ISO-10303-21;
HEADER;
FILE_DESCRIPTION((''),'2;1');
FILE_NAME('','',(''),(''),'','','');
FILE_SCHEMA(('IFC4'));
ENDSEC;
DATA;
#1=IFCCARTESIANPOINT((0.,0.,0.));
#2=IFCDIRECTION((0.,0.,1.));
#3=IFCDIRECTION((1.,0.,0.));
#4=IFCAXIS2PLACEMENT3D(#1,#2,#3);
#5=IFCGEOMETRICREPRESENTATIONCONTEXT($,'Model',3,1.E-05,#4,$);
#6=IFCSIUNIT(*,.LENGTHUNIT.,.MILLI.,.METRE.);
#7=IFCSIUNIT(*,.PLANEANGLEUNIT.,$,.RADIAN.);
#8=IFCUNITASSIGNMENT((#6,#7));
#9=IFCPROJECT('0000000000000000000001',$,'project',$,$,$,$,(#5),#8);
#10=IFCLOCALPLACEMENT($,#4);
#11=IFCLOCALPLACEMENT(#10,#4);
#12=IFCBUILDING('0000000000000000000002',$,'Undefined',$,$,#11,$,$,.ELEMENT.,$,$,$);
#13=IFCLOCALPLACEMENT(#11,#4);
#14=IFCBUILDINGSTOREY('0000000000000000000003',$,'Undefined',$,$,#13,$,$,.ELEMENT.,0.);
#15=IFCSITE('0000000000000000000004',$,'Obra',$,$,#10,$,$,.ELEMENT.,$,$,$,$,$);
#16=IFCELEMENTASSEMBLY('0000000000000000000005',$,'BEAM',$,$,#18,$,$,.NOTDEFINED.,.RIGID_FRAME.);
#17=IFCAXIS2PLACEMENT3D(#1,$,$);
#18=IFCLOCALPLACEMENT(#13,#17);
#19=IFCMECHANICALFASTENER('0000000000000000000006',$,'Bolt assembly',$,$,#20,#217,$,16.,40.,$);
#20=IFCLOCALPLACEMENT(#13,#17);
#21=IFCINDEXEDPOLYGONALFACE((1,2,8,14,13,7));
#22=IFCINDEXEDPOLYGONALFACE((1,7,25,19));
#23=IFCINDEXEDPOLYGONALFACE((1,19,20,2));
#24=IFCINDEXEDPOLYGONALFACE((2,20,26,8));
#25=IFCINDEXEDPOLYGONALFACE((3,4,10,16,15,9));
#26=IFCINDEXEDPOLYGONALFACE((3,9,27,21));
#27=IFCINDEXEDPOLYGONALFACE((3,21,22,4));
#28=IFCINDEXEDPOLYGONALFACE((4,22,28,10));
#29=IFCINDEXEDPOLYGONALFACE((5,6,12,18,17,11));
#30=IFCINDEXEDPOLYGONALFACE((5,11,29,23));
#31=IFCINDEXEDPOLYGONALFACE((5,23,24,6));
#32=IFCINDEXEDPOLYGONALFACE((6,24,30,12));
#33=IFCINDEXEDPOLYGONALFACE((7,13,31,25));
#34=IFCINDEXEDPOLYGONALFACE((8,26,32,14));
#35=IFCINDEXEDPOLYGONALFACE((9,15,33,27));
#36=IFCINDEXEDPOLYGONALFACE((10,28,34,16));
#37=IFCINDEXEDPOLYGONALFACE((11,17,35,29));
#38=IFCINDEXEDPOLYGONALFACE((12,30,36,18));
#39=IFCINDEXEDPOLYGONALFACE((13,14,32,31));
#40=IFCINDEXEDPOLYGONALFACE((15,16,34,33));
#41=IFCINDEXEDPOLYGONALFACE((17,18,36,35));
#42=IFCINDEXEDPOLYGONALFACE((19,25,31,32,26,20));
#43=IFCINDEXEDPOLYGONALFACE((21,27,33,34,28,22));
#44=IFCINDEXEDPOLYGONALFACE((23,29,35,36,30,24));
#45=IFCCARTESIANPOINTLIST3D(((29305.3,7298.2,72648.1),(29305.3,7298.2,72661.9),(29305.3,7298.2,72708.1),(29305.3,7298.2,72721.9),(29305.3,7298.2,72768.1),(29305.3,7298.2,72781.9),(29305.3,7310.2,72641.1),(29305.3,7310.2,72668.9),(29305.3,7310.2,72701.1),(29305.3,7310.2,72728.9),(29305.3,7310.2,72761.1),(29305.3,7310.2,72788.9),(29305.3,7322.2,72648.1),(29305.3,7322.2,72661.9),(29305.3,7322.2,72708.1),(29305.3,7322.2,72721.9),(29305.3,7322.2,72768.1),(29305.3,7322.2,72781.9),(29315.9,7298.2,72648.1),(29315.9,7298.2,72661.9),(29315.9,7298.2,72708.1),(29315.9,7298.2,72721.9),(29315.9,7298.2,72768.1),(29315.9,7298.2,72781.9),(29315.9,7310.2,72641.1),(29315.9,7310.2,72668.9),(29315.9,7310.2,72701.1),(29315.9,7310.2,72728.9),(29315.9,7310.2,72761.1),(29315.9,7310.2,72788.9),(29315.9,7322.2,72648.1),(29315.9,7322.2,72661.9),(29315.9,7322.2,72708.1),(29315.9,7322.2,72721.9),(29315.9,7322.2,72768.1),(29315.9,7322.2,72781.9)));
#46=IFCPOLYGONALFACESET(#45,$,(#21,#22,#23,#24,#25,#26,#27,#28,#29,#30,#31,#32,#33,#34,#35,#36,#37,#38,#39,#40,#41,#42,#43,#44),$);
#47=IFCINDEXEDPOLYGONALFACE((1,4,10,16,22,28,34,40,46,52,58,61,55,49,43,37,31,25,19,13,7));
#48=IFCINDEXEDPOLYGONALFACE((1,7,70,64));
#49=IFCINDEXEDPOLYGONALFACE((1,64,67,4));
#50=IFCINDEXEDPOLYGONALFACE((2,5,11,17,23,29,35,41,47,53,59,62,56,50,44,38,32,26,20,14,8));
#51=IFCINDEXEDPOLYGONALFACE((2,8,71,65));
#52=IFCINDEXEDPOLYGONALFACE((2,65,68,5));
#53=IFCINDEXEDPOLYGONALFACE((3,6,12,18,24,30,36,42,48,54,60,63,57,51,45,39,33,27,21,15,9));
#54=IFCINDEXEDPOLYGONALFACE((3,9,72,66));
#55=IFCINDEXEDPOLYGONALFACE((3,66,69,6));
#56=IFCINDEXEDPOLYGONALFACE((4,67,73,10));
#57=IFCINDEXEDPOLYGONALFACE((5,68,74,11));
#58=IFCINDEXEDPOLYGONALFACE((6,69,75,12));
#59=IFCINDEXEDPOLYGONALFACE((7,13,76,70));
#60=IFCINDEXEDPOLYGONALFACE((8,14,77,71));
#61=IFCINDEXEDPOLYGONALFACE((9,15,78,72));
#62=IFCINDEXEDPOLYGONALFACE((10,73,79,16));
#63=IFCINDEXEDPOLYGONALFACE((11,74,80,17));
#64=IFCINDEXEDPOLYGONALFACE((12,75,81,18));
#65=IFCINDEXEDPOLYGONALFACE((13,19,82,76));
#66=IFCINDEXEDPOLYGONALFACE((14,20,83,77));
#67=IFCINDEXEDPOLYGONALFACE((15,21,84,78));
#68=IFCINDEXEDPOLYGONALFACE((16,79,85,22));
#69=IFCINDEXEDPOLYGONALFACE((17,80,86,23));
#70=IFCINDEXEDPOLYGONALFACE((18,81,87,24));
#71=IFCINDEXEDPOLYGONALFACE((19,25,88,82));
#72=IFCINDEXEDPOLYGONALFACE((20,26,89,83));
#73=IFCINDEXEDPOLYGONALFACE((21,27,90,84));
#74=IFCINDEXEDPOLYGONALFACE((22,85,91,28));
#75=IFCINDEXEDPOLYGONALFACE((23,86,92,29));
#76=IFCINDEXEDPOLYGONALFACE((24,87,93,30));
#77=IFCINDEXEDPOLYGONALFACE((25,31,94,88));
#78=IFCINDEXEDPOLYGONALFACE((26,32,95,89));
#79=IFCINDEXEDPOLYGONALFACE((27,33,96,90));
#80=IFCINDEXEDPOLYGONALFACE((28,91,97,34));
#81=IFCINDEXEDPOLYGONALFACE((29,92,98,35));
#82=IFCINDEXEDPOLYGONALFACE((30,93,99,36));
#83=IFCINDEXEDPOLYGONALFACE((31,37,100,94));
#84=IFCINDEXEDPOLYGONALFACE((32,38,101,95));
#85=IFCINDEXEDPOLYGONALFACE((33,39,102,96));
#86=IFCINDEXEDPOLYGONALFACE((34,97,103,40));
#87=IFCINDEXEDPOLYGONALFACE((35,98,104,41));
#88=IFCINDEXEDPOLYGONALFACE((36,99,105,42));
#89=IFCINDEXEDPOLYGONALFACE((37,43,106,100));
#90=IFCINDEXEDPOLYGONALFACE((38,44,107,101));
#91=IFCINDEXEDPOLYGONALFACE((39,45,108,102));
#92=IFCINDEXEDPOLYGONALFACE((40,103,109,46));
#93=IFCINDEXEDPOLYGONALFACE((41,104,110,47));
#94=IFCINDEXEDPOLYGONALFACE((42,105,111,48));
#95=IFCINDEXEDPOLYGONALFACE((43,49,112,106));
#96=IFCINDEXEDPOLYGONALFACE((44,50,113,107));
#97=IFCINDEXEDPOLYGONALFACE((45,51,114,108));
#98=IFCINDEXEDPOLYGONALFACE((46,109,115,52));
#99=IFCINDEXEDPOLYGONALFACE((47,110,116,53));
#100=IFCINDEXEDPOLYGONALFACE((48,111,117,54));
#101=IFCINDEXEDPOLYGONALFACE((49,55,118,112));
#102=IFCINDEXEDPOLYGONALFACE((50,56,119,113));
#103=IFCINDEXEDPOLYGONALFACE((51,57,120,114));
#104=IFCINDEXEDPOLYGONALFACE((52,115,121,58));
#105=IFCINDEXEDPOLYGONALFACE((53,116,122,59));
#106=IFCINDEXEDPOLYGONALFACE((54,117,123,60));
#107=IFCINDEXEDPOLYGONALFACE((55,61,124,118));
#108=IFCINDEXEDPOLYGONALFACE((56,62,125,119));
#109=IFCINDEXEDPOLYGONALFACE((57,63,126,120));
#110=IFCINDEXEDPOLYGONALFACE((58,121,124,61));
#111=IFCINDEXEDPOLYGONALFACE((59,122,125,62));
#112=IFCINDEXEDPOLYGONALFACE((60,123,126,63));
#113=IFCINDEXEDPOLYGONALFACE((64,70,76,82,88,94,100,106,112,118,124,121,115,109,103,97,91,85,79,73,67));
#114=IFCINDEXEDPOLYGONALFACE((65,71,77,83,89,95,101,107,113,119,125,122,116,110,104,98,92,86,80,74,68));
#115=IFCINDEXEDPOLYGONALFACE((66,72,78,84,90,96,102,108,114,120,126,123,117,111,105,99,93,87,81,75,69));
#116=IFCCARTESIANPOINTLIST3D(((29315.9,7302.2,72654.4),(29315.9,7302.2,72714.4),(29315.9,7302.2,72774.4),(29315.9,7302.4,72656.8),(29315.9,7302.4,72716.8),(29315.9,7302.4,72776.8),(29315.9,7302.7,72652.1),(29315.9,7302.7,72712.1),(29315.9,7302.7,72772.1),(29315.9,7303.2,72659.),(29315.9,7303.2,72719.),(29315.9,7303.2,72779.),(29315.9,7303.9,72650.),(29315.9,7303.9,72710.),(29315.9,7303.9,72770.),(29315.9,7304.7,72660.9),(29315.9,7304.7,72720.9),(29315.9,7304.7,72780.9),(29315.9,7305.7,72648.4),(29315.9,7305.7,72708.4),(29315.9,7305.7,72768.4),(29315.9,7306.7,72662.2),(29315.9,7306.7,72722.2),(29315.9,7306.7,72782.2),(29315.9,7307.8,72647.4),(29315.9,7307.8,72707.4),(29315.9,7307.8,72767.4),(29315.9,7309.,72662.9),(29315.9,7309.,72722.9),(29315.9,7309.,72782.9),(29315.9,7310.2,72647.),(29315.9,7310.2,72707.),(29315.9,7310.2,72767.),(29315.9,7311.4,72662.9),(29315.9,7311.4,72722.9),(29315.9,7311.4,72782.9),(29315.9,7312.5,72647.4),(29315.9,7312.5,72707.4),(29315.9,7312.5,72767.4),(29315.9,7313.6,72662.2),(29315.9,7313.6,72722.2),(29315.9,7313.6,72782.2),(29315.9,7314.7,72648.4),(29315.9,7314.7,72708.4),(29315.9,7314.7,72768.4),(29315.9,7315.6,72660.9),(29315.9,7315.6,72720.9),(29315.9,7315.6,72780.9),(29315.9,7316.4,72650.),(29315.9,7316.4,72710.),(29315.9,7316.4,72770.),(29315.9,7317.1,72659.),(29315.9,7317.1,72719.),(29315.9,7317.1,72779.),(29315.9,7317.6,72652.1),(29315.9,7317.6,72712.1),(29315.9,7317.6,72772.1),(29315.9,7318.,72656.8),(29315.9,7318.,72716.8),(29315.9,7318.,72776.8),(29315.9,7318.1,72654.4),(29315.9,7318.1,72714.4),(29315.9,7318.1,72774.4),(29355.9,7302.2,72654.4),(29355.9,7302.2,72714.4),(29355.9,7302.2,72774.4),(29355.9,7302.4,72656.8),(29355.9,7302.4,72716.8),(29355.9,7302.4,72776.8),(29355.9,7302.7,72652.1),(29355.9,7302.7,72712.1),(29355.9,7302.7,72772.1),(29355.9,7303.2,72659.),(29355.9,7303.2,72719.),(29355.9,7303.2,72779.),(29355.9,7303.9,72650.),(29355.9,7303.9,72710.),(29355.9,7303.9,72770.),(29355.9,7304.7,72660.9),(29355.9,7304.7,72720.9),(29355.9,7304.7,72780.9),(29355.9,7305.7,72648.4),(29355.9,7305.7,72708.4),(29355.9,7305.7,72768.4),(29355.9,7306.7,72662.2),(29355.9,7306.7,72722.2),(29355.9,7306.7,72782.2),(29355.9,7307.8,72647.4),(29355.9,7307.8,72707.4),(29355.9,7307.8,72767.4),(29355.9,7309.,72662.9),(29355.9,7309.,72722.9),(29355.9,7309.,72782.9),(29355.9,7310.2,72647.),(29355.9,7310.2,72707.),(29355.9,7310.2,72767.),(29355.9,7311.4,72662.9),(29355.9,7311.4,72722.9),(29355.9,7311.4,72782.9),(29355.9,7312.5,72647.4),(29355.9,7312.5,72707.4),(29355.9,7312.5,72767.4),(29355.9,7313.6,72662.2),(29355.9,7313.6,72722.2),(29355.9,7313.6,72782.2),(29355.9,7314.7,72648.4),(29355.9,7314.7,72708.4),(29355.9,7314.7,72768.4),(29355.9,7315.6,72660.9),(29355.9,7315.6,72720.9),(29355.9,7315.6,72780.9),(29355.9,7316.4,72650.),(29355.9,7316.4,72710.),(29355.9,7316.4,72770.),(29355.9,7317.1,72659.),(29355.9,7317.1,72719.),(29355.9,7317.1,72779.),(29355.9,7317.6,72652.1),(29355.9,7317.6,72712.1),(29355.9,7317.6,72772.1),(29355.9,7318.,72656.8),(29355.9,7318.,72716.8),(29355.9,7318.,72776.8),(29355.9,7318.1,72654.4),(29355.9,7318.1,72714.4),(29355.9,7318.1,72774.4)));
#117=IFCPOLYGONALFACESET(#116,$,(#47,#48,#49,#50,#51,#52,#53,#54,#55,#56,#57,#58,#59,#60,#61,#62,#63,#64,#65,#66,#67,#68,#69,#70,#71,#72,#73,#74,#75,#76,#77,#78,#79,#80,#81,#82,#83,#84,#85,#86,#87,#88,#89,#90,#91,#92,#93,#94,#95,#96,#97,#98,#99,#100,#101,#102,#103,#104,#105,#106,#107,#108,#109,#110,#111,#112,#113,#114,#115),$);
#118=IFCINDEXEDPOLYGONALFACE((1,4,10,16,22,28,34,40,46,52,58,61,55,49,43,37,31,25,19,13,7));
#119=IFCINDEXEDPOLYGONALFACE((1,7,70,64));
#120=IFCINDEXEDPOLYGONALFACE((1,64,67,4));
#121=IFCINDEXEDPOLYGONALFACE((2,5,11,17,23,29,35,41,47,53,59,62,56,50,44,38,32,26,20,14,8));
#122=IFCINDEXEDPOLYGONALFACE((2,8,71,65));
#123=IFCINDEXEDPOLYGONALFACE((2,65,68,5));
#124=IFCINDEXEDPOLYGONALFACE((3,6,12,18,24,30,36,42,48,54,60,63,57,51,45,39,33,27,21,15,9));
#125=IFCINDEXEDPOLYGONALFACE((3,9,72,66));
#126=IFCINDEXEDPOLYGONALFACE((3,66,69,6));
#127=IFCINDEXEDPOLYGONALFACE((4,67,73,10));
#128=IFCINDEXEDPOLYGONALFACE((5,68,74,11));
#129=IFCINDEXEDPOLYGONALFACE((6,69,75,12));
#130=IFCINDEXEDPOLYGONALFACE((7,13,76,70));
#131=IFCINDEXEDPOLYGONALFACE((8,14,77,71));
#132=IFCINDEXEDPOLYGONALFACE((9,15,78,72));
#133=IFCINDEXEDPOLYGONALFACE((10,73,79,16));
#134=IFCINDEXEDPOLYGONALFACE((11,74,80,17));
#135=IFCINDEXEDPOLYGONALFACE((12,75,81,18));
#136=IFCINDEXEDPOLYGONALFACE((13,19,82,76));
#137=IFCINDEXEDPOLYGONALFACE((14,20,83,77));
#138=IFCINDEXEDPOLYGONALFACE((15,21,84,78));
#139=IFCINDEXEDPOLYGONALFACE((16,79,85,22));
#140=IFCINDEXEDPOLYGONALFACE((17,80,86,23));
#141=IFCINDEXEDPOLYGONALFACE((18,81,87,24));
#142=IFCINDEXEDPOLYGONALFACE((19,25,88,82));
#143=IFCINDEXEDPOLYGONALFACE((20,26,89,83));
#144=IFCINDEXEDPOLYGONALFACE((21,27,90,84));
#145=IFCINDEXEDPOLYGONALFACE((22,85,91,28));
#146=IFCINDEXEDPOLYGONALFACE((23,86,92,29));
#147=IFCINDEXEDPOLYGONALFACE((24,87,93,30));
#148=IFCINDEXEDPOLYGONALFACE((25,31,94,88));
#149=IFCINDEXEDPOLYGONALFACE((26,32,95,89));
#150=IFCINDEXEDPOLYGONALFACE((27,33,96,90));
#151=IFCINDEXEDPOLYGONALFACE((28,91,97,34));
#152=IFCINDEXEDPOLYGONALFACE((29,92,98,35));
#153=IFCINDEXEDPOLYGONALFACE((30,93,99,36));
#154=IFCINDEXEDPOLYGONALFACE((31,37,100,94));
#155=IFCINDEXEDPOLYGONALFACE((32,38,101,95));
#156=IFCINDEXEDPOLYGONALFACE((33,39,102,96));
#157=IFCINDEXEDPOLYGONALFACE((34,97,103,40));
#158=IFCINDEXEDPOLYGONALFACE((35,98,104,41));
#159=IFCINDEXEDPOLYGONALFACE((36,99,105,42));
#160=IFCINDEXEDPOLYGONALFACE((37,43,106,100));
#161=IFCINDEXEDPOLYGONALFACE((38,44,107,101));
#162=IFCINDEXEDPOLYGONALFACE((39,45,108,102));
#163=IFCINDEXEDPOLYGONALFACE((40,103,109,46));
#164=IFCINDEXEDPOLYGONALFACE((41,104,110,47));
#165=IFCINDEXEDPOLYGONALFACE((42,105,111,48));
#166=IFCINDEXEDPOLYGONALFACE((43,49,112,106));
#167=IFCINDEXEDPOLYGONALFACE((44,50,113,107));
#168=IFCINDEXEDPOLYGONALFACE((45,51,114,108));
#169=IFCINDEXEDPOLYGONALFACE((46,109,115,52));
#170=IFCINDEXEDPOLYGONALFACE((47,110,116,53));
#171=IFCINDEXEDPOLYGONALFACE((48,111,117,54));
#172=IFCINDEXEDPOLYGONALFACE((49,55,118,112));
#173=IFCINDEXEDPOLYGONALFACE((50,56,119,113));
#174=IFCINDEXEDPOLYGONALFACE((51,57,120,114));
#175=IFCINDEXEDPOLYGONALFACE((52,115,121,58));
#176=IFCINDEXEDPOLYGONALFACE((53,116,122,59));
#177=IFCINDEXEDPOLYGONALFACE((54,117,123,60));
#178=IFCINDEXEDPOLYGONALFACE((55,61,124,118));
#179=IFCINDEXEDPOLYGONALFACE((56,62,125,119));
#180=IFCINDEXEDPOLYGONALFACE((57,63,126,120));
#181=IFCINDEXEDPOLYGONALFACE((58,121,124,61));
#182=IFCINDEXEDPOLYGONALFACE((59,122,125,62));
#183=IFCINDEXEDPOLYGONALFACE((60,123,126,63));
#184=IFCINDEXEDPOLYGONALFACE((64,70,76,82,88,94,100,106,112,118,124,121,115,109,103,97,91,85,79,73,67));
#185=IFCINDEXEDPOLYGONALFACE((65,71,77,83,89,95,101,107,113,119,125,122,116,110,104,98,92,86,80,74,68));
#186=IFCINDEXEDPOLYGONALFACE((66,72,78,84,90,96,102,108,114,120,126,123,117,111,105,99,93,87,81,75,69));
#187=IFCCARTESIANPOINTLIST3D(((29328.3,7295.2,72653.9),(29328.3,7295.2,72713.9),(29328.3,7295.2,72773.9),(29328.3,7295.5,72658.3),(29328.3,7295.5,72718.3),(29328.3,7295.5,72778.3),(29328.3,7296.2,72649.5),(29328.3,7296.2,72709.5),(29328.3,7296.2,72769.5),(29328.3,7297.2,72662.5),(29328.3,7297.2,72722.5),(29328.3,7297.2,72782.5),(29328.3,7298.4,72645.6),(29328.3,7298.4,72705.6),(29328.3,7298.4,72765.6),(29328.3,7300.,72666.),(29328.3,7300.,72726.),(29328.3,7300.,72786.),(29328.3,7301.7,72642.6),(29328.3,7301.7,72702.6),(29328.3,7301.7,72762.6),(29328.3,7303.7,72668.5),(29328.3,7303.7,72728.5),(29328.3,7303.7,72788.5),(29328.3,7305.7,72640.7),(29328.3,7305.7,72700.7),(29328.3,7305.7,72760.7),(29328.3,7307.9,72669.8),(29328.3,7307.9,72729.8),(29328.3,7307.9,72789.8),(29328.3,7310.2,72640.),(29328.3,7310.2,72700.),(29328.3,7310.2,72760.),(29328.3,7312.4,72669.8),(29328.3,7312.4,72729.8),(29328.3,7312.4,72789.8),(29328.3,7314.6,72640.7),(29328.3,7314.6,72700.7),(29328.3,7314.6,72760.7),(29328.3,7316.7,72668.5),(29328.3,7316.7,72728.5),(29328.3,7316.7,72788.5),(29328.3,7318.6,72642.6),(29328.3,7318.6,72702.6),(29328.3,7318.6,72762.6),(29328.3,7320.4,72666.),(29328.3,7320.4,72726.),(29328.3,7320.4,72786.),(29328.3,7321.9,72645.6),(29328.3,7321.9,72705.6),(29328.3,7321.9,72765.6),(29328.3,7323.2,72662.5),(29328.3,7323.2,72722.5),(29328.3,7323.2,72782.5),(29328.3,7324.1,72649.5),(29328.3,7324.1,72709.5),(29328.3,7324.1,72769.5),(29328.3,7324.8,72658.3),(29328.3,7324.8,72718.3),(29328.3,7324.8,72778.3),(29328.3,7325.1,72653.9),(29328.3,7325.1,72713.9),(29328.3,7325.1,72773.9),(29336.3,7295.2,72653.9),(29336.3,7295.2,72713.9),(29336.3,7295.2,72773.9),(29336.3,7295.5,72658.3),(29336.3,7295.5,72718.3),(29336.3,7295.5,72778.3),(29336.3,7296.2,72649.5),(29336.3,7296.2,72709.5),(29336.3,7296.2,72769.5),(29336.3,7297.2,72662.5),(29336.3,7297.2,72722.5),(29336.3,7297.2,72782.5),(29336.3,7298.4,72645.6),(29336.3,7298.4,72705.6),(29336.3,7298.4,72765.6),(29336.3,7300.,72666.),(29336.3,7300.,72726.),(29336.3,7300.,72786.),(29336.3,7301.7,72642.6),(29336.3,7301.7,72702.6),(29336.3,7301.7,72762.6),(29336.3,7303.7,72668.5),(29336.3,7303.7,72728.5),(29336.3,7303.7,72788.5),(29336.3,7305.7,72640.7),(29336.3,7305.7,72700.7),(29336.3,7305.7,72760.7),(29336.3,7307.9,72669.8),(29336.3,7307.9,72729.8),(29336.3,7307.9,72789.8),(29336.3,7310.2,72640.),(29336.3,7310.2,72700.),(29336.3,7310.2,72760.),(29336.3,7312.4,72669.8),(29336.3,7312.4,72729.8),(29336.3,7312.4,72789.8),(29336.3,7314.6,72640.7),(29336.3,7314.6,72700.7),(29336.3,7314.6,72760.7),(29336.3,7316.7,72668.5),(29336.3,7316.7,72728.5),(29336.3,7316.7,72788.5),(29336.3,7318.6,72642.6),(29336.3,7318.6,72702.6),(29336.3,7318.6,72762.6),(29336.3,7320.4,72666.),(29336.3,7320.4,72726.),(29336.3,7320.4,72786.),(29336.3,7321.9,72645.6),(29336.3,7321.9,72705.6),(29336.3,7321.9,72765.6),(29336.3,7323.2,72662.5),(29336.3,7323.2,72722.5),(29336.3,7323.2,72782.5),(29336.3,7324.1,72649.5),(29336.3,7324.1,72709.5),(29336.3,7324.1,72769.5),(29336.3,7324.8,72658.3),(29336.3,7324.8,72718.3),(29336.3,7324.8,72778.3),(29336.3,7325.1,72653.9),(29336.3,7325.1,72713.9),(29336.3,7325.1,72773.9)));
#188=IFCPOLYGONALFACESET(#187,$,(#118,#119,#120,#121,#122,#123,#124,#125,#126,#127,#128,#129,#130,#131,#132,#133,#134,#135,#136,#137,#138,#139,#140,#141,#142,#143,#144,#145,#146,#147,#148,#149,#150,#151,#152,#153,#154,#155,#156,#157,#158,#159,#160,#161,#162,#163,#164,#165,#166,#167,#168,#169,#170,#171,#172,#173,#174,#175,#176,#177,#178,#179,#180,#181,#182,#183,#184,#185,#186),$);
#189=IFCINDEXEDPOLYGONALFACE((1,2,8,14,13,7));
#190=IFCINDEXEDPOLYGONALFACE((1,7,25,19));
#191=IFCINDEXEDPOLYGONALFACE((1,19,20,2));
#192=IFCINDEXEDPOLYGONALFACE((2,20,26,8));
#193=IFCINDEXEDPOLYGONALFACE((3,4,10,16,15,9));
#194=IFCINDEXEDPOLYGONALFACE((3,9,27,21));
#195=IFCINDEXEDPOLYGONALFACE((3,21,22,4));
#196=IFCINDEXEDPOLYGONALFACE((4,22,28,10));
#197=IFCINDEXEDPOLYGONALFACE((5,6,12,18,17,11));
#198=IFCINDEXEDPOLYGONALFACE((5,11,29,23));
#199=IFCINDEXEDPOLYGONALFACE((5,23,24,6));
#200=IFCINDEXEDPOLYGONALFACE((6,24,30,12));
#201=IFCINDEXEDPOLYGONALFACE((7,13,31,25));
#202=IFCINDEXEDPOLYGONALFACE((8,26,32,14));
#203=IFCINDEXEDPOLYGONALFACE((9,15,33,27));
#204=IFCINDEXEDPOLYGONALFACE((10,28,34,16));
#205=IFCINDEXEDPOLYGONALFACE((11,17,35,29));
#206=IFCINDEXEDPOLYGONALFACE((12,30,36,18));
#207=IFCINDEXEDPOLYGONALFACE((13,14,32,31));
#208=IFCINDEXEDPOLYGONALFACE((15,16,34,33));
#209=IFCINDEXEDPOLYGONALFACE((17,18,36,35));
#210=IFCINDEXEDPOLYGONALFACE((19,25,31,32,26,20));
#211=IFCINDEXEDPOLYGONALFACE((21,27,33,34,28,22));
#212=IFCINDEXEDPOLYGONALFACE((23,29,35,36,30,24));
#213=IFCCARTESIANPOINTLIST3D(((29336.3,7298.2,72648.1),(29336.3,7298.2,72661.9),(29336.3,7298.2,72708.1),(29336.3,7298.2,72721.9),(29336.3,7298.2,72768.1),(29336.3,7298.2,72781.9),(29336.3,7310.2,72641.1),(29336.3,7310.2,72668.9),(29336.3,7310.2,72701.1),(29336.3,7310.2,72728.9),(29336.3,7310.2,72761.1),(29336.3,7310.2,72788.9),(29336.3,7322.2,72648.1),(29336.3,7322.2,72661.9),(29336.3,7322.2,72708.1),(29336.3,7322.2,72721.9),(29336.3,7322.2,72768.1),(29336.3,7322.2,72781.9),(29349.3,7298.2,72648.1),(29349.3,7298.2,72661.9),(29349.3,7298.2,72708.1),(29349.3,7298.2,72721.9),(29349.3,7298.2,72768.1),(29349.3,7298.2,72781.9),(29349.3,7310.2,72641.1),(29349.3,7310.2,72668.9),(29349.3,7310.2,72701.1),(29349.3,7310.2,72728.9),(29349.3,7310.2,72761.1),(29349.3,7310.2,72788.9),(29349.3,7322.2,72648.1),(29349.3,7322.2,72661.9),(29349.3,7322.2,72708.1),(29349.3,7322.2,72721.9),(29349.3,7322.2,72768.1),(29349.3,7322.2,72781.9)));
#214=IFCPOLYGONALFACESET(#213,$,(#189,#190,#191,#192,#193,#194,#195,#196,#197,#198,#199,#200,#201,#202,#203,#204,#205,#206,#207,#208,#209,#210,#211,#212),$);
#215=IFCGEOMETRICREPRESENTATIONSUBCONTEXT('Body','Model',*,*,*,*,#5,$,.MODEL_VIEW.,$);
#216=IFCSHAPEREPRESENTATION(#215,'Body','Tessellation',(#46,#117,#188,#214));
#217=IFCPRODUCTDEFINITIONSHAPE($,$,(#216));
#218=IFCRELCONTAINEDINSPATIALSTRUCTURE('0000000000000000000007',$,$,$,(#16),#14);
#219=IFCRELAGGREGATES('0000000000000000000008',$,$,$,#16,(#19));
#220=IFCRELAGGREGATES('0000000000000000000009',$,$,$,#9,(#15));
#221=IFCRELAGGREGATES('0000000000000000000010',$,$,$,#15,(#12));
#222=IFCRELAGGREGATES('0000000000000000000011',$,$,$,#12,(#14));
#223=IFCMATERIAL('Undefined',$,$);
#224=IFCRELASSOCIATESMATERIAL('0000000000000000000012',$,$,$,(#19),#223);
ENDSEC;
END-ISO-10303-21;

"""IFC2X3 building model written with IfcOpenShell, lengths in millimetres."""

from ifc_helpers import new_model, si_unit, frame, origin_with_axes, origin_2d_with_axis, place, context, subcontext, project, spatial, polyline, circle, outline, extrude, source, transform, mapped, material, element, aggregate, save


model = new_model("IFC2X3")

# Units and contexts
model_context = context("Model", 3, precision=1e-05, world=origin_with_axes())
body_context = subcontext(model_context, "Body", "Model", "MODEL_VIEW")
ifc_project = project(units=[si_unit("LENGTHUNIT", "METRE", prefix="MILLI"), si_unit("PLANEANGLEUNIT", "RADIAN")], contexts=[model_context])

# Site, building, storey
site_placement = place(None, origin_with_axes())
site = spatial("IfcSite", under=ifc_project, at=site_placement, Name="Obra", CompositionType="ELEMENT")
building_placement = place(site_placement, origin_with_axes())
building = spatial("IfcBuilding", under=site, at=building_placement, Name="Undefined", CompositionType="ELEMENT")
storey_placement = place(building_placement, origin_with_axes())
storey = spatial("IfcBuildingStorey", under=building, at=storey_placement, Name="Undefined", CompositionType="ELEMENT", Elevation=0.0)

# Element assembly, mechanical fastener
assembly_1_placement = place(storey_placement, origin_with_axes())
assembly_1 = element("IfcElementAssembly", 1, at=assembly_1_placement, inside=storey, Name="BEAM", AssemblyPlace="NOTDEFINED", PredefinedType="RIGID_FRAME")
ifc_material = material(Name="Undefined")
shared_shape_1 = source(origin_with_axes(), body_context, "Body", "SweptSolid", [
    extrude(outline(polyline([(13.9, 0.0), (6.9, 12.0), (-6.9, 12.0), (-13.9, 0.0), (-6.9, -12.0), (6.9, -12.0), (13.9, 0.0)])), frame((0.0, -19.7, 0.0), z_axis=(0.0, 1.0, 0.0), x_axis=(1.0, 0.0, 0.0)), (0.0, 0.0, 1.0), 10.6),
    extrude(circle(Radius=8.0, at=origin_2d_with_axis()), frame((0.0, -9.1, 0.0), z_axis=(0.0, 1.0, 0.0), x_axis=(1.0, 0.0, 0.0)), (0.0, 0.0, 1.0), 40.0),
    extrude(circle(Radius=15.0, at=origin_2d_with_axis()), frame((0.0, 3.3, 0.0), z_axis=(0.0, 1.0, 0.0), x_axis=(1.0, 0.0, 0.0)), (0.0, 0.0, 1.0), 8.0),
    extrude(outline(polyline([(13.9, 0.0), (6.9, 12.0), (-6.9, 12.0), (-13.9, 0.0), (-6.9, -12.0), (6.9, -12.0), (13.9, 0.0)])), frame((0.0, 11.3, 0.0), z_axis=(0.0, 1.0, 0.0), x_axis=(1.0, 0.0, 0.0)), (0.0, 0.0, 1.0), 13.0),
])
mechanical_fastener_1_placement = place(assembly_1_placement, frame((29325.0, 7360.2, 72835.0), z_axis=(0.000005, -1.0, 0.0), x_axis=(0.0, 0.0, -1.0)))
mechanical_fastener_1 = element("IfcMechanicalFastener", 2, at=mechanical_fastener_1_placement, material=ifc_material, Name="Bolt assembly", NominalDiameter=16.0, NominalLength=40.0, context=body_context, shape_type="MappedRepresentation", body=[
    mapped(shared_shape_1, transform((60.0, 0.0, 50.0))),
    mapped(shared_shape_1, transform((120.0, 0.0, 50.0))),
    mapped(shared_shape_1, transform((180.0, 0.0, 50.0))),
])
aggregate(assembly_1, [mechanical_fastener_1])

save(model, "model.ifc")
